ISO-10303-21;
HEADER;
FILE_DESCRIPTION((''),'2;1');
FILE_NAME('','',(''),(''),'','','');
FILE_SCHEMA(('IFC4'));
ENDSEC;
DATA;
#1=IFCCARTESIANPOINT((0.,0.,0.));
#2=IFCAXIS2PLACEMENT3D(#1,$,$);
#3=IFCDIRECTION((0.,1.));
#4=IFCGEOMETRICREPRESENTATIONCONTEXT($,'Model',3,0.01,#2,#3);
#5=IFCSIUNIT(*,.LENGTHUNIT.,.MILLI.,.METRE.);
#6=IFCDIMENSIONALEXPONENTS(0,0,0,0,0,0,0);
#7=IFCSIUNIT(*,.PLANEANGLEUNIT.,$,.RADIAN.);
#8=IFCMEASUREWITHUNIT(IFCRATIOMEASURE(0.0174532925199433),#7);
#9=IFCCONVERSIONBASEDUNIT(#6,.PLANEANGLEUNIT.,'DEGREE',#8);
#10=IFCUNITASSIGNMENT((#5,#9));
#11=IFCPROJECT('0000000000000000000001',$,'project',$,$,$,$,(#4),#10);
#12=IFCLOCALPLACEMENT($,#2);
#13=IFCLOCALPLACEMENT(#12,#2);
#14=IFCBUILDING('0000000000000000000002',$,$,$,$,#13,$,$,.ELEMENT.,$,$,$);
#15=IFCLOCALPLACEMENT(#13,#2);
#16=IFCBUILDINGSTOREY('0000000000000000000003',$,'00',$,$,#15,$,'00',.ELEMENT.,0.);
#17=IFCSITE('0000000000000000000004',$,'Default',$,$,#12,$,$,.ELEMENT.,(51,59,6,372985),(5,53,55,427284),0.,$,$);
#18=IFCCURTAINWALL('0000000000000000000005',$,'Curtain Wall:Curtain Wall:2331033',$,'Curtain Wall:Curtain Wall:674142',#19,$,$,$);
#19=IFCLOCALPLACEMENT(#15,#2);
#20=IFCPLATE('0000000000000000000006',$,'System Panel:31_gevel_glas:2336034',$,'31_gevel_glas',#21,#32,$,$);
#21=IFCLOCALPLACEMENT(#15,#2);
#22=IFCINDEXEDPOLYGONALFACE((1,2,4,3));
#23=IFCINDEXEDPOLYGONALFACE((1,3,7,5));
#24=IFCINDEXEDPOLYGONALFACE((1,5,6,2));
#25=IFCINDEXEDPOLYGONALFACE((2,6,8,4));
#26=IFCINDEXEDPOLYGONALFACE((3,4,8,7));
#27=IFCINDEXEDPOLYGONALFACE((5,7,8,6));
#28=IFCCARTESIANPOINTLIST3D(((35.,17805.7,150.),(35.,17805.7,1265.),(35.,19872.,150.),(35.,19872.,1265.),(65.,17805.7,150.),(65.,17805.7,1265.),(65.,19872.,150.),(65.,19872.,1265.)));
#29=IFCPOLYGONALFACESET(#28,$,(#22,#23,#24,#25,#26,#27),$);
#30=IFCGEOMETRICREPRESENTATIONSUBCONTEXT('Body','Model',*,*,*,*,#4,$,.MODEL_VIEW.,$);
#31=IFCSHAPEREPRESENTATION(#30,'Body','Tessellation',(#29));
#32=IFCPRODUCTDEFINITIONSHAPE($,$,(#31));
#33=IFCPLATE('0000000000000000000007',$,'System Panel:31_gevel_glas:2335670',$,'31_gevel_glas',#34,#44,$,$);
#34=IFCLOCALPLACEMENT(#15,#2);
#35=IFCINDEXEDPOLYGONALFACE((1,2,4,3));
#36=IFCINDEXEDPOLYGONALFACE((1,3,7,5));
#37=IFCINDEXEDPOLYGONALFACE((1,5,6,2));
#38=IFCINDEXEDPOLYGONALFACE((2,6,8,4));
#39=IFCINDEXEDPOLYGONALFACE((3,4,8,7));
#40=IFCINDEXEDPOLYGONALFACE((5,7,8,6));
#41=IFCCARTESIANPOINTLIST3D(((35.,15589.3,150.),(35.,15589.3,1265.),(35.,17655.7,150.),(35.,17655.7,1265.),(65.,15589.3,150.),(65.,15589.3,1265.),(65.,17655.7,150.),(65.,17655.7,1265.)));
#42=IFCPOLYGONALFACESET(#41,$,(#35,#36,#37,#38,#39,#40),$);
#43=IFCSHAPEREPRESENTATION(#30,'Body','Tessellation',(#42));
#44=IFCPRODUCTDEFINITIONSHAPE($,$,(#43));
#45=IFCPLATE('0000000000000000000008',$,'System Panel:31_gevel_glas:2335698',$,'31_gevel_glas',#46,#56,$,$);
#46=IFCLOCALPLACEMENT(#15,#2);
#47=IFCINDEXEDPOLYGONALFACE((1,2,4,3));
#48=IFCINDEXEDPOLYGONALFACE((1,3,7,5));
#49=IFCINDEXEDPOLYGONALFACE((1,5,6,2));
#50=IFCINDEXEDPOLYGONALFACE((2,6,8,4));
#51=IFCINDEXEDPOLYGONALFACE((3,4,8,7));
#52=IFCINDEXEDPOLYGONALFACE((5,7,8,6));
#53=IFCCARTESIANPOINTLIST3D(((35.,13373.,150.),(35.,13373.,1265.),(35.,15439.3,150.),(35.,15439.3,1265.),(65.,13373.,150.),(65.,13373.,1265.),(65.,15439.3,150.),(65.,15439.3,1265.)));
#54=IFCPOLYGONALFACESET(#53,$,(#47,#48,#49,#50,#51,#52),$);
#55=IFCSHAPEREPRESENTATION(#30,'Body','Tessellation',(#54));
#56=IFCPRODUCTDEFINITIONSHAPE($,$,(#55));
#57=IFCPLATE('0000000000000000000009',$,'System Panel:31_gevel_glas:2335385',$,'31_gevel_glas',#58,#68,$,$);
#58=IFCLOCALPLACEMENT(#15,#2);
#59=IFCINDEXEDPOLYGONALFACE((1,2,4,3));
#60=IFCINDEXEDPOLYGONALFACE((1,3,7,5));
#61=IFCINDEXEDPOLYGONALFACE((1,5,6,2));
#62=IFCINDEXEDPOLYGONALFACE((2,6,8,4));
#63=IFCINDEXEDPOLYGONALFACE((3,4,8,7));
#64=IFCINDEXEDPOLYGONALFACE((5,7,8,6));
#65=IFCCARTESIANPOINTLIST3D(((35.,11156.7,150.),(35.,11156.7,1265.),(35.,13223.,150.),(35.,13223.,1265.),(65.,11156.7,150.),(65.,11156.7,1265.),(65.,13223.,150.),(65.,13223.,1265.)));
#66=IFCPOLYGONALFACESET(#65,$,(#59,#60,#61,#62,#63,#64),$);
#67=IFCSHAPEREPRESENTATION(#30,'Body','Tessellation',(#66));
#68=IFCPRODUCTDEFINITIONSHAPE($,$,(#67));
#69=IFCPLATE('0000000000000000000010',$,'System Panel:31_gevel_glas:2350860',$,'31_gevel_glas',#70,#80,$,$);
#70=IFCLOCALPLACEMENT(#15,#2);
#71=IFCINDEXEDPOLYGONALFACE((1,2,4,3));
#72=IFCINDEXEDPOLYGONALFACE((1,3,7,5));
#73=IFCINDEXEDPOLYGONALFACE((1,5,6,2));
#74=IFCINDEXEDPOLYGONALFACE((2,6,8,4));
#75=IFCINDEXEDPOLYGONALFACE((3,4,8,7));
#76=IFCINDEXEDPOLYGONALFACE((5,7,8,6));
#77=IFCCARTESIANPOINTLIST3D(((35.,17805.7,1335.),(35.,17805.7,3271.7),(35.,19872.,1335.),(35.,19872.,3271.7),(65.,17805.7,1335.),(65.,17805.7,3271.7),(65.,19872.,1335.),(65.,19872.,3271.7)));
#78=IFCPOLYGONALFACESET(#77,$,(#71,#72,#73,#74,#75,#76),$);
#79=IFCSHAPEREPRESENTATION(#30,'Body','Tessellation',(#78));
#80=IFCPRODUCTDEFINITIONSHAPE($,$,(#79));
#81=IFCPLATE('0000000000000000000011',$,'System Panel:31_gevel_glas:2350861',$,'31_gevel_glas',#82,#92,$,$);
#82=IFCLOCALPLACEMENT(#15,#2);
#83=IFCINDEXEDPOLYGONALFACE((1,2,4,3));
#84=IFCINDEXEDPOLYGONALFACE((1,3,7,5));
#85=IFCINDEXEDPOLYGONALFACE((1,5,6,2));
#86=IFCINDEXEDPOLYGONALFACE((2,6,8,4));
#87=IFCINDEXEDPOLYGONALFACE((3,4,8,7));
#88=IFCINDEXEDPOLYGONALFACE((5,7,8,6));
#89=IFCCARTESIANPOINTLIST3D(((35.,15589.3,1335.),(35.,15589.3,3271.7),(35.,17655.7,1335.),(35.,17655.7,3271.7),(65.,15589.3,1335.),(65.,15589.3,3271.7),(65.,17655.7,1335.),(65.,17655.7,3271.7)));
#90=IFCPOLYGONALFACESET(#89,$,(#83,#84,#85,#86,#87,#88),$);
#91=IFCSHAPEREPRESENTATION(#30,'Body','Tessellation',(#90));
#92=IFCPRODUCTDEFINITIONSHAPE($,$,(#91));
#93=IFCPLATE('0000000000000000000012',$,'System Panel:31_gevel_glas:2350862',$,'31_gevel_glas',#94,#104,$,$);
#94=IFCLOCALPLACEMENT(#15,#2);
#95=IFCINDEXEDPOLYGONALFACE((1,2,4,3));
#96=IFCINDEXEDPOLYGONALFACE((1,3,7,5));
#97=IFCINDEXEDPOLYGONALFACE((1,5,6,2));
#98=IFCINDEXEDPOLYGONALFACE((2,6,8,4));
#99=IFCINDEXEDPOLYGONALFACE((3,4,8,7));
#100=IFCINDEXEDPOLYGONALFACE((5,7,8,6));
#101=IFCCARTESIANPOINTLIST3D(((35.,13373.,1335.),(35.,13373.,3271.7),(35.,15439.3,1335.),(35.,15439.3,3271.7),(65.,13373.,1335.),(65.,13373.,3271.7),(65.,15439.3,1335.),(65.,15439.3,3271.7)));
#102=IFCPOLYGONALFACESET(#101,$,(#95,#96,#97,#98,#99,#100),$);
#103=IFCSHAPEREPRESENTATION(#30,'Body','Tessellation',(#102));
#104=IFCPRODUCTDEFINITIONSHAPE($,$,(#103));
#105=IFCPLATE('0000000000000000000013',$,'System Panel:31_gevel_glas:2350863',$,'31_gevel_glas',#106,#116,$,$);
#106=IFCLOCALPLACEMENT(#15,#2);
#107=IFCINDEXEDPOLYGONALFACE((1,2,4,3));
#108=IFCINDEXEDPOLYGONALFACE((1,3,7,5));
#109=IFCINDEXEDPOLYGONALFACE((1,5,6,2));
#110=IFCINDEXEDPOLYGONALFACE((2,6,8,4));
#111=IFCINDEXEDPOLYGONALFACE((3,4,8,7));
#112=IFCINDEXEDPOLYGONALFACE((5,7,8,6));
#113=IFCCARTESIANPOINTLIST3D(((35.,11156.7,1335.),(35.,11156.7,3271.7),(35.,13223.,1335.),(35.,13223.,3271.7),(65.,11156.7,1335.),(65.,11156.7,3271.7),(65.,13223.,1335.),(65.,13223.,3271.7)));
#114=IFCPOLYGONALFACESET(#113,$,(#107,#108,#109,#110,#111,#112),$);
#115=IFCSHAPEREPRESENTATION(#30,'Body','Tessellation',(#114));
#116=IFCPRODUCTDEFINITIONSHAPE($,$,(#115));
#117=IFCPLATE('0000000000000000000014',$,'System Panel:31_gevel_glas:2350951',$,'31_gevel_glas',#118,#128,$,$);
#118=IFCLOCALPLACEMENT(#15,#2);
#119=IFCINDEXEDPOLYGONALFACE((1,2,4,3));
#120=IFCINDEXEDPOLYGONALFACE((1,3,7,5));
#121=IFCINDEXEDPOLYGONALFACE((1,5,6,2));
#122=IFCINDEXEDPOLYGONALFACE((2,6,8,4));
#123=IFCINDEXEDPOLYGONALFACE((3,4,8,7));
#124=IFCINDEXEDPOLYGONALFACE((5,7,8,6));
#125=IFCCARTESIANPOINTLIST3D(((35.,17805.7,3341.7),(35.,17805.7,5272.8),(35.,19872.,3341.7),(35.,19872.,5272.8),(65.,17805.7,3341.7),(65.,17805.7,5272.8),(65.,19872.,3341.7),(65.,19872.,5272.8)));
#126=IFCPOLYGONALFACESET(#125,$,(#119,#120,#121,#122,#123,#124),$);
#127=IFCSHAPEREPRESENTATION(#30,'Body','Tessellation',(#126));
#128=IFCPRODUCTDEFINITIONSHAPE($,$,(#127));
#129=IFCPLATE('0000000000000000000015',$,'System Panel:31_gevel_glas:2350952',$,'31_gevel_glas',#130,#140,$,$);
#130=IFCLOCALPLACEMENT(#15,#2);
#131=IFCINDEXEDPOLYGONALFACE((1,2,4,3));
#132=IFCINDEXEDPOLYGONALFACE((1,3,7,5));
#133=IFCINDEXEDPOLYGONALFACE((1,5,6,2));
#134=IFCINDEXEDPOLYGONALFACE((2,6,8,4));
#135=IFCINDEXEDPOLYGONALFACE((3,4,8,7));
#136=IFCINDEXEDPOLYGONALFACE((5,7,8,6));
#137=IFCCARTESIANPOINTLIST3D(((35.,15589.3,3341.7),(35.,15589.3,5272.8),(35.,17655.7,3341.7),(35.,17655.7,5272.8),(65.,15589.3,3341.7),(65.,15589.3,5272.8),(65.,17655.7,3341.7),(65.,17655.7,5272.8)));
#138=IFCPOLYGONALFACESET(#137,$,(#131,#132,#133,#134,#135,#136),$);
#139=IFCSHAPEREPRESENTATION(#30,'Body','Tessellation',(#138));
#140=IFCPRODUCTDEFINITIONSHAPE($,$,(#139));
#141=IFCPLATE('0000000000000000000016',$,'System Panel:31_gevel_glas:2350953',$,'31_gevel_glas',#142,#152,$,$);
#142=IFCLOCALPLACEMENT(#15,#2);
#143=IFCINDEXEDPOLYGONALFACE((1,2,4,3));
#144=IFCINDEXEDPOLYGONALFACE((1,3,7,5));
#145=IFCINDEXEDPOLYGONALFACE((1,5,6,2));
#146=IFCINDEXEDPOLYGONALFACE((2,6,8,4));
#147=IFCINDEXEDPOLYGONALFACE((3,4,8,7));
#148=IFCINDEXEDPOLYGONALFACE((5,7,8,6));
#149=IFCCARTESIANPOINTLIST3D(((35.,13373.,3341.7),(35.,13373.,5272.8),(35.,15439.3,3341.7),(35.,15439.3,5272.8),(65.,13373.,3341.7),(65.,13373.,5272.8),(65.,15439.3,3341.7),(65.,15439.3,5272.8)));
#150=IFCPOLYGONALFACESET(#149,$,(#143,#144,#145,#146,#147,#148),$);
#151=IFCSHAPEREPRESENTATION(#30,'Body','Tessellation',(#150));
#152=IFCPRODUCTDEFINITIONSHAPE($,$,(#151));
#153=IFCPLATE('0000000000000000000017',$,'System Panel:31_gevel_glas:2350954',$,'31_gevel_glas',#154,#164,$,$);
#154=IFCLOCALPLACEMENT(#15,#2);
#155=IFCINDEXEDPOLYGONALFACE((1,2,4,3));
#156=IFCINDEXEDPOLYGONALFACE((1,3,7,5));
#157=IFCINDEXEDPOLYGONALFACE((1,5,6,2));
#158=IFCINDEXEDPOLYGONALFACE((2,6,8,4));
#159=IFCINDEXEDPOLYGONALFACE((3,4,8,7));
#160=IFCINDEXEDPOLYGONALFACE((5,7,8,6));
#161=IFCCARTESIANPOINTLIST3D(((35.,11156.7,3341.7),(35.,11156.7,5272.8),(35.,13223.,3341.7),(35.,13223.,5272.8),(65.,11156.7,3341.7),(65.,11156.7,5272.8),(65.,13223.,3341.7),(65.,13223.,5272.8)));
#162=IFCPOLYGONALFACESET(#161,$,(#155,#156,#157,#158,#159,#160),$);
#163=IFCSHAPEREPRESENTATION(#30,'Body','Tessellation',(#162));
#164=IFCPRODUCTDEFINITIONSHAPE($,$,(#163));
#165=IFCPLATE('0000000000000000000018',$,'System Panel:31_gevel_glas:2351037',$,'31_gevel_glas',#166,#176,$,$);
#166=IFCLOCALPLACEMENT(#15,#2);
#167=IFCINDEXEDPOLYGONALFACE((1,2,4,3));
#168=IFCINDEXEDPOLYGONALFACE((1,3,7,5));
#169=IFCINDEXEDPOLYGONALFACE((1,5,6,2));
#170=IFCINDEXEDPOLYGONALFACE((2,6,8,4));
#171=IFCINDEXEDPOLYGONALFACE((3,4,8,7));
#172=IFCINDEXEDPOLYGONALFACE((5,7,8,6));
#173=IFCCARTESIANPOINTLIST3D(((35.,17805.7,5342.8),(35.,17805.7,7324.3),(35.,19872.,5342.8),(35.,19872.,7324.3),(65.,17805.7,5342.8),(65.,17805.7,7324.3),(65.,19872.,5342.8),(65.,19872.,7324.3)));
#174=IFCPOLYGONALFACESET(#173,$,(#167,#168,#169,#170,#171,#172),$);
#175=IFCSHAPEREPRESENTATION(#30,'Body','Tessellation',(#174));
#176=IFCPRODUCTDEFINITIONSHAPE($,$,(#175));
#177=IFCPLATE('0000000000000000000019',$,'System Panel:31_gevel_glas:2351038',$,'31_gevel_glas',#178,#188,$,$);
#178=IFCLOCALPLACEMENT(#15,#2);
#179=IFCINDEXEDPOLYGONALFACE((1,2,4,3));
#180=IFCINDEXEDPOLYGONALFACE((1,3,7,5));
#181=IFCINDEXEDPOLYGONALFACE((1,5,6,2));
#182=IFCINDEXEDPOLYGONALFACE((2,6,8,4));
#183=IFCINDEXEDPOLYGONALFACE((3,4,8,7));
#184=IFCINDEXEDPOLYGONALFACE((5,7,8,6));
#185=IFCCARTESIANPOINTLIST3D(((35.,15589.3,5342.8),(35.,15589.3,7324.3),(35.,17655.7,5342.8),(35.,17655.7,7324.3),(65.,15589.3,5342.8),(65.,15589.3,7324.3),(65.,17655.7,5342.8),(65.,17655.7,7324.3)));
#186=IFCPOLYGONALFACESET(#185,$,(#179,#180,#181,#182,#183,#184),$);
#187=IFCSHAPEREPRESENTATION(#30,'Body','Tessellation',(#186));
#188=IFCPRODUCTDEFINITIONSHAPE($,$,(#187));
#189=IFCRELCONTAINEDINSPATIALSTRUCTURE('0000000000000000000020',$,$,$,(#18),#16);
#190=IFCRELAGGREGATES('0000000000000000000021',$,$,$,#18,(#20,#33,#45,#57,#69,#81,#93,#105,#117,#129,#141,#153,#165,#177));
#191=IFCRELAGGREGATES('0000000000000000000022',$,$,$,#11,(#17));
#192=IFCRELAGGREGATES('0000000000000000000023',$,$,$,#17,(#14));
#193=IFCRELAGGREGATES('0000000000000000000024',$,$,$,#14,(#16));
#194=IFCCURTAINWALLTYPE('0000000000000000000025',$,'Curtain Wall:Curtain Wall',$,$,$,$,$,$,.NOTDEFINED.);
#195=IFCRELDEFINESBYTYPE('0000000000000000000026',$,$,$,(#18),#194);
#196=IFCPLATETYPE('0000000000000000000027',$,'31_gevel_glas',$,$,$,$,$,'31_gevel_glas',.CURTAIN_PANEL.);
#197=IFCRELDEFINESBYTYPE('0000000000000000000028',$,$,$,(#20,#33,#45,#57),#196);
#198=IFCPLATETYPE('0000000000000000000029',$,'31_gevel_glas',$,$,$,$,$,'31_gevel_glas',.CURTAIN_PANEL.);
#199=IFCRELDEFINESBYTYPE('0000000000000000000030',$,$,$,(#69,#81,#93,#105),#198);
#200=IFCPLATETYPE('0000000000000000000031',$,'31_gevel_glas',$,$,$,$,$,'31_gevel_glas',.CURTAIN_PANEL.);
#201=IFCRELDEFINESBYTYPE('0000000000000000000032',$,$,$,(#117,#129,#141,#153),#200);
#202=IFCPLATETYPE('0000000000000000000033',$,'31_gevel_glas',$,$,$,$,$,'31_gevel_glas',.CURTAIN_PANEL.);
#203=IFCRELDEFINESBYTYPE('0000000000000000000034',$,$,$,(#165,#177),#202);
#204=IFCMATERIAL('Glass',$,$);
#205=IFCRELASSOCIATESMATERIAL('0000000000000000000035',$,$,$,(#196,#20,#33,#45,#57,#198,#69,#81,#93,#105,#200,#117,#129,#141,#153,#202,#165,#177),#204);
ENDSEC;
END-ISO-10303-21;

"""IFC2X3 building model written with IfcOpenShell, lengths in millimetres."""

from ifc_helpers import new_model, entity, si_unit, converted_unit, direction, frame, origin, origin_2d_with_axis, place, context, subcontext, project, spatial, rectangle, extrude, source, transform, mapped, material, type_object, type_shapes, element, aggregate, save


model = new_model("IFC2X3")

# Units and contexts
model_context = context("Model", 3, precision=0.01, world=origin(), true_north=direction((0.0, 1.0)))
body_context = subcontext(model_context, "Body", "Model", "MODEL_VIEW")
ifc_project = project(units=[si_unit("LENGTHUNIT", "METRE", prefix="MILLI"), converted_unit("PLANEANGLEUNIT", "DEGREE", entity("IfcRatioMeasure", 0.0174532925199433), si_unit("PLANEANGLEUNIT", "RADIAN"), dimensions=[0, 0, 0, 0, 0, 0, 0])], contexts=[model_context])

# Site, building, storey
site_placement = place(None, origin())
site = spatial("IfcSite", under=ifc_project, at=site_placement, Name="Default", CompositionType="ELEMENT", RefLatitude=(51, 59, 6, 372985), RefLongitude=(5, 53, 55, 427284), RefElevation=0.0)
building_placement = place(site_placement, origin())
building = spatial("IfcBuilding", under=site, at=building_placement, CompositionType="ELEMENT")
storey_placement = place(building_placement, origin())
storey = spatial("IfcBuildingStorey", under=building, at=storey_placement, Name="00", LongName="00", CompositionType="ELEMENT", Elevation=0.0)

# Curtain wall, plates
curtain_wall_type = type_object("IfcCurtainWallType", Name="Curtain Wall:Curtain Wall", PredefinedType="NOTDEFINED")
curtain_wall_placement = place(storey_placement, origin())
curtain_wall = element("IfcCurtainWall", 1, at=curtain_wall_placement, inside=storey, type_object=curtain_wall_type, Name="Curtain Wall:Curtain Wall:2331033", ObjectType="Curtain Wall:Curtain Wall:674142")
ifc_material_1 = material(Name="Glass")
plate_type_1 = type_object("IfcPlateType", Name="31_gevel_glas", ElementType="31_gevel_glas", PredefinedType="CURTAIN_PANEL", material=ifc_material_1)
shared_shape_1 = source(origin(), body_context, "Body", "SweptSolid", [
    extrude(rectangle(XDim=30.0, YDim=2066.3, at=origin_2d_with_axis()), frame((0.0, 50.0, 0.0), z_axis=(0.0, 0.0, 1.0), x_axis=(0.0, 1.0, 0.0)), (0.0, 0.0, 1.0), 1115.0),
])
type_shapes(plate_type_1, [shared_shape_1])
plate_1_placement = place(curtain_wall_placement, frame((0.0, 18838.8, 150.0), z_axis=(0.0, 0.0, 1.0), x_axis=(0.0, -1.0, 0.0)))
plate_1 = element("IfcPlate", 2, at=plate_1_placement, type_object=plate_type_1, material=ifc_material_1, Name="System Panel:31_gevel_glas:2336034", ObjectType="31_gevel_glas", context=body_context, shape_type="MappedRepresentation", body=[
    mapped(shared_shape_1, transform((0.0, 0.0, 0.0), scale=1.0)),
])
plate_2_placement = place(curtain_wall_placement, frame((0.0, 16622.5, 150.0), z_axis=(0.0, 0.0, 1.0), x_axis=(0.0, -1.0, 0.0)))
plate_2 = element("IfcPlate", 3, at=plate_2_placement, type_object=plate_type_1, material=ifc_material_1, Name="System Panel:31_gevel_glas:2335670", ObjectType="31_gevel_glas", context=body_context, shape_type="MappedRepresentation", body=[
    mapped(shared_shape_1, transform((0.0, 0.0, 0.0), scale=1.0)),
])
plate_3_placement = place(curtain_wall_placement, frame((0.0, 14406.2, 150.0), z_axis=(0.0, 0.0, 1.0), x_axis=(0.0, -1.0, 0.0)))
plate_3 = element("IfcPlate", 4, at=plate_3_placement, type_object=plate_type_1, material=ifc_material_1, Name="System Panel:31_gevel_glas:2335698", ObjectType="31_gevel_glas", context=body_context, shape_type="MappedRepresentation", body=[
    mapped(shared_shape_1, transform((0.0, 0.0, 0.0), scale=1.0)),
])
plate_4_placement = place(curtain_wall_placement, frame((0.0, 12189.8, 150.0), z_axis=(0.0, 0.0, 1.0), x_axis=(0.0, -1.0, 0.0)))
plate_4 = element("IfcPlate", 5, at=plate_4_placement, type_object=plate_type_1, material=ifc_material_1, Name="System Panel:31_gevel_glas:2335385", ObjectType="31_gevel_glas", context=body_context, shape_type="MappedRepresentation", body=[
    mapped(shared_shape_1, transform((0.0, 0.0, 0.0), scale=1.0)),
])
plate_type_2 = type_object("IfcPlateType", Name="31_gevel_glas", ElementType="31_gevel_glas", PredefinedType="CURTAIN_PANEL", material=ifc_material_1)
shared_shape_2 = source(origin(), body_context, "Body", "SweptSolid", [
    extrude(rectangle(XDim=30.0, YDim=2066.3, at=origin_2d_with_axis()), frame((0.0, 50.0, 0.0), z_axis=(0.0, 0.0, 1.0), x_axis=(0.0, 1.0, 0.0)), (0.0, 0.0, 1.0), 1936.7),
])
type_shapes(plate_type_2, [shared_shape_2])
plate_5_placement = place(curtain_wall_placement, frame((0.0, 18838.8, 1335.0), z_axis=(0.0, 0.0, 1.0), x_axis=(0.0, -1.0, 0.0)))
plate_5 = element("IfcPlate", 6, at=plate_5_placement, type_object=plate_type_2, material=ifc_material_1, Name="System Panel:31_gevel_glas:2350860", ObjectType="31_gevel_glas", context=body_context, shape_type="MappedRepresentation", body=[
    mapped(shared_shape_2, transform((0.0, 0.0, 0.0), scale=1.0)),
])
plate_6_placement = place(curtain_wall_placement, frame((0.0, 16622.5, 1335.0), z_axis=(0.0, 0.0, 1.0), x_axis=(0.0, -1.0, 0.0)))
plate_6 = element("IfcPlate", 7, at=plate_6_placement, type_object=plate_type_2, material=ifc_material_1, Name="System Panel:31_gevel_glas:2350861", ObjectType="31_gevel_glas", context=body_context, shape_type="MappedRepresentation", body=[
    mapped(shared_shape_2, transform((0.0, 0.0, 0.0), scale=1.0)),
])
plate_7_placement = place(curtain_wall_placement, frame((0.0, 14406.2, 1335.0), z_axis=(0.0, 0.0, 1.0), x_axis=(0.0, -1.0, 0.0)))
plate_7 = element("IfcPlate", 8, at=plate_7_placement, type_object=plate_type_2, material=ifc_material_1, Name="System Panel:31_gevel_glas:2350862", ObjectType="31_gevel_glas", context=body_context, shape_type="MappedRepresentation", body=[
    mapped(shared_shape_2, transform((0.0, 0.0, 0.0), scale=1.0)),
])
plate_8_placement = place(curtain_wall_placement, frame((0.0, 12189.8, 1335.0), z_axis=(0.0, 0.0, 1.0), x_axis=(0.0, -1.0, 0.0)))
plate_8 = element("IfcPlate", 9, at=plate_8_placement, type_object=plate_type_2, material=ifc_material_1, Name="System Panel:31_gevel_glas:2350863", ObjectType="31_gevel_glas", context=body_context, shape_type="MappedRepresentation", body=[
    mapped(shared_shape_2, transform((0.0, 0.0, 0.0), scale=1.0)),
])
plate_type_3 = type_object("IfcPlateType", Name="31_gevel_glas", ElementType="31_gevel_glas", PredefinedType="CURTAIN_PANEL", material=ifc_material_1)
shared_shape_3 = source(origin(), body_context, "Body", "SweptSolid", [
    extrude(rectangle(XDim=30.0, YDim=2066.3, at=origin_2d_with_axis()), frame((0.0, 50.0, 0.0), z_axis=(0.0, 0.0, 1.0), x_axis=(0.0, 1.0, 0.0)), (0.0, 0.0, 1.0), 1931.1),
])
type_shapes(plate_type_3, [shared_shape_3])
plate_9_placement = place(curtain_wall_placement, frame((0.0, 18838.8, 3341.7), z_axis=(0.0, 0.0, 1.0), x_axis=(0.0, -1.0, 0.0)))
plate_9 = element("IfcPlate", 10, at=plate_9_placement, type_object=plate_type_3, material=ifc_material_1, Name="System Panel:31_gevel_glas:2350951", ObjectType="31_gevel_glas", context=body_context, shape_type="MappedRepresentation", body=[
    mapped(shared_shape_3, transform((0.0, 0.0, 0.0), scale=1.0)),
])
plate_10_placement = place(curtain_wall_placement, frame((0.0, 16622.5, 3341.7), z_axis=(0.0, 0.0, 1.0), x_axis=(0.0, -1.0, 0.0)))
plate_10 = element("IfcPlate", 11, at=plate_10_placement, type_object=plate_type_3, material=ifc_material_1, Name="System Panel:31_gevel_glas:2350952", ObjectType="31_gevel_glas", context=body_context, shape_type="MappedRepresentation", body=[
    mapped(shared_shape_3, transform((0.0, 0.0, 0.0), scale=1.0)),
])
plate_11_placement = place(curtain_wall_placement, frame((0.0, 14406.2, 3341.7), z_axis=(0.0, 0.0, 1.0), x_axis=(0.0, -1.0, 0.0)))
plate_11 = element("IfcPlate", 12, at=plate_11_placement, type_object=plate_type_3, material=ifc_material_1, Name="System Panel:31_gevel_glas:2350953", ObjectType="31_gevel_glas", context=body_context, shape_type="MappedRepresentation", body=[
    mapped(shared_shape_3, transform((0.0, 0.0, 0.0), scale=1.0)),
])
plate_12_placement = place(curtain_wall_placement, frame((0.0, 12189.8, 3341.7), z_axis=(0.0, 0.0, 1.0), x_axis=(0.0, -1.0, 0.0)))
plate_12 = element("IfcPlate", 13, at=plate_12_placement, type_object=plate_type_3, material=ifc_material_1, Name="System Panel:31_gevel_glas:2350954", ObjectType="31_gevel_glas", context=body_context, shape_type="MappedRepresentation", body=[
    mapped(shared_shape_3, transform((0.0, 0.0, 0.0), scale=1.0)),
])
plate_type_4 = type_object("IfcPlateType", Name="31_gevel_glas", ElementType="31_gevel_glas", PredefinedType="CURTAIN_PANEL", material=ifc_material_1)
shared_shape_4 = source(origin(), body_context, "Body", "SweptSolid", [
    extrude(rectangle(XDim=30.0, YDim=2066.3, at=origin_2d_with_axis()), frame((0.0, 50.0, 0.0), z_axis=(0.0, 0.0, 1.0), x_axis=(0.0, 1.0, 0.0)), (0.0, 0.0, 1.0), 1981.5),
])
type_shapes(plate_type_4, [shared_shape_4])
plate_13_placement = place(curtain_wall_placement, frame((0.0, 18838.8, 5342.8), z_axis=(0.0, 0.0, 1.0), x_axis=(0.0, -1.0, 0.0)))
plate_13 = element("IfcPlate", 14, at=plate_13_placement, type_object=plate_type_4, material=ifc_material_1, Name="System Panel:31_gevel_glas:2351037", ObjectType="31_gevel_glas", context=body_context, shape_type="MappedRepresentation", body=[
    mapped(shared_shape_4, transform((0.0, 0.0, 0.0), scale=1.0)),
])
plate_14_placement = place(curtain_wall_placement, frame((0.0, 16622.5, 5342.8), z_axis=(0.0, 0.0, 1.0), x_axis=(0.0, -1.0, 0.0)))
plate_14 = element("IfcPlate", 15, at=plate_14_placement, type_object=plate_type_4, material=ifc_material_1, Name="System Panel:31_gevel_glas:2351038", ObjectType="31_gevel_glas", context=body_context, shape_type="MappedRepresentation", body=[
    mapped(shared_shape_4, transform((0.0, 0.0, 0.0), scale=1.0)),
])
aggregate(curtain_wall, [plate_1, plate_2, plate_3, plate_4, plate_5, plate_6, plate_7, plate_8, plate_9, plate_10, plate_11, plate_12, plate_13, plate_14])

save(model, "model.ifc")
